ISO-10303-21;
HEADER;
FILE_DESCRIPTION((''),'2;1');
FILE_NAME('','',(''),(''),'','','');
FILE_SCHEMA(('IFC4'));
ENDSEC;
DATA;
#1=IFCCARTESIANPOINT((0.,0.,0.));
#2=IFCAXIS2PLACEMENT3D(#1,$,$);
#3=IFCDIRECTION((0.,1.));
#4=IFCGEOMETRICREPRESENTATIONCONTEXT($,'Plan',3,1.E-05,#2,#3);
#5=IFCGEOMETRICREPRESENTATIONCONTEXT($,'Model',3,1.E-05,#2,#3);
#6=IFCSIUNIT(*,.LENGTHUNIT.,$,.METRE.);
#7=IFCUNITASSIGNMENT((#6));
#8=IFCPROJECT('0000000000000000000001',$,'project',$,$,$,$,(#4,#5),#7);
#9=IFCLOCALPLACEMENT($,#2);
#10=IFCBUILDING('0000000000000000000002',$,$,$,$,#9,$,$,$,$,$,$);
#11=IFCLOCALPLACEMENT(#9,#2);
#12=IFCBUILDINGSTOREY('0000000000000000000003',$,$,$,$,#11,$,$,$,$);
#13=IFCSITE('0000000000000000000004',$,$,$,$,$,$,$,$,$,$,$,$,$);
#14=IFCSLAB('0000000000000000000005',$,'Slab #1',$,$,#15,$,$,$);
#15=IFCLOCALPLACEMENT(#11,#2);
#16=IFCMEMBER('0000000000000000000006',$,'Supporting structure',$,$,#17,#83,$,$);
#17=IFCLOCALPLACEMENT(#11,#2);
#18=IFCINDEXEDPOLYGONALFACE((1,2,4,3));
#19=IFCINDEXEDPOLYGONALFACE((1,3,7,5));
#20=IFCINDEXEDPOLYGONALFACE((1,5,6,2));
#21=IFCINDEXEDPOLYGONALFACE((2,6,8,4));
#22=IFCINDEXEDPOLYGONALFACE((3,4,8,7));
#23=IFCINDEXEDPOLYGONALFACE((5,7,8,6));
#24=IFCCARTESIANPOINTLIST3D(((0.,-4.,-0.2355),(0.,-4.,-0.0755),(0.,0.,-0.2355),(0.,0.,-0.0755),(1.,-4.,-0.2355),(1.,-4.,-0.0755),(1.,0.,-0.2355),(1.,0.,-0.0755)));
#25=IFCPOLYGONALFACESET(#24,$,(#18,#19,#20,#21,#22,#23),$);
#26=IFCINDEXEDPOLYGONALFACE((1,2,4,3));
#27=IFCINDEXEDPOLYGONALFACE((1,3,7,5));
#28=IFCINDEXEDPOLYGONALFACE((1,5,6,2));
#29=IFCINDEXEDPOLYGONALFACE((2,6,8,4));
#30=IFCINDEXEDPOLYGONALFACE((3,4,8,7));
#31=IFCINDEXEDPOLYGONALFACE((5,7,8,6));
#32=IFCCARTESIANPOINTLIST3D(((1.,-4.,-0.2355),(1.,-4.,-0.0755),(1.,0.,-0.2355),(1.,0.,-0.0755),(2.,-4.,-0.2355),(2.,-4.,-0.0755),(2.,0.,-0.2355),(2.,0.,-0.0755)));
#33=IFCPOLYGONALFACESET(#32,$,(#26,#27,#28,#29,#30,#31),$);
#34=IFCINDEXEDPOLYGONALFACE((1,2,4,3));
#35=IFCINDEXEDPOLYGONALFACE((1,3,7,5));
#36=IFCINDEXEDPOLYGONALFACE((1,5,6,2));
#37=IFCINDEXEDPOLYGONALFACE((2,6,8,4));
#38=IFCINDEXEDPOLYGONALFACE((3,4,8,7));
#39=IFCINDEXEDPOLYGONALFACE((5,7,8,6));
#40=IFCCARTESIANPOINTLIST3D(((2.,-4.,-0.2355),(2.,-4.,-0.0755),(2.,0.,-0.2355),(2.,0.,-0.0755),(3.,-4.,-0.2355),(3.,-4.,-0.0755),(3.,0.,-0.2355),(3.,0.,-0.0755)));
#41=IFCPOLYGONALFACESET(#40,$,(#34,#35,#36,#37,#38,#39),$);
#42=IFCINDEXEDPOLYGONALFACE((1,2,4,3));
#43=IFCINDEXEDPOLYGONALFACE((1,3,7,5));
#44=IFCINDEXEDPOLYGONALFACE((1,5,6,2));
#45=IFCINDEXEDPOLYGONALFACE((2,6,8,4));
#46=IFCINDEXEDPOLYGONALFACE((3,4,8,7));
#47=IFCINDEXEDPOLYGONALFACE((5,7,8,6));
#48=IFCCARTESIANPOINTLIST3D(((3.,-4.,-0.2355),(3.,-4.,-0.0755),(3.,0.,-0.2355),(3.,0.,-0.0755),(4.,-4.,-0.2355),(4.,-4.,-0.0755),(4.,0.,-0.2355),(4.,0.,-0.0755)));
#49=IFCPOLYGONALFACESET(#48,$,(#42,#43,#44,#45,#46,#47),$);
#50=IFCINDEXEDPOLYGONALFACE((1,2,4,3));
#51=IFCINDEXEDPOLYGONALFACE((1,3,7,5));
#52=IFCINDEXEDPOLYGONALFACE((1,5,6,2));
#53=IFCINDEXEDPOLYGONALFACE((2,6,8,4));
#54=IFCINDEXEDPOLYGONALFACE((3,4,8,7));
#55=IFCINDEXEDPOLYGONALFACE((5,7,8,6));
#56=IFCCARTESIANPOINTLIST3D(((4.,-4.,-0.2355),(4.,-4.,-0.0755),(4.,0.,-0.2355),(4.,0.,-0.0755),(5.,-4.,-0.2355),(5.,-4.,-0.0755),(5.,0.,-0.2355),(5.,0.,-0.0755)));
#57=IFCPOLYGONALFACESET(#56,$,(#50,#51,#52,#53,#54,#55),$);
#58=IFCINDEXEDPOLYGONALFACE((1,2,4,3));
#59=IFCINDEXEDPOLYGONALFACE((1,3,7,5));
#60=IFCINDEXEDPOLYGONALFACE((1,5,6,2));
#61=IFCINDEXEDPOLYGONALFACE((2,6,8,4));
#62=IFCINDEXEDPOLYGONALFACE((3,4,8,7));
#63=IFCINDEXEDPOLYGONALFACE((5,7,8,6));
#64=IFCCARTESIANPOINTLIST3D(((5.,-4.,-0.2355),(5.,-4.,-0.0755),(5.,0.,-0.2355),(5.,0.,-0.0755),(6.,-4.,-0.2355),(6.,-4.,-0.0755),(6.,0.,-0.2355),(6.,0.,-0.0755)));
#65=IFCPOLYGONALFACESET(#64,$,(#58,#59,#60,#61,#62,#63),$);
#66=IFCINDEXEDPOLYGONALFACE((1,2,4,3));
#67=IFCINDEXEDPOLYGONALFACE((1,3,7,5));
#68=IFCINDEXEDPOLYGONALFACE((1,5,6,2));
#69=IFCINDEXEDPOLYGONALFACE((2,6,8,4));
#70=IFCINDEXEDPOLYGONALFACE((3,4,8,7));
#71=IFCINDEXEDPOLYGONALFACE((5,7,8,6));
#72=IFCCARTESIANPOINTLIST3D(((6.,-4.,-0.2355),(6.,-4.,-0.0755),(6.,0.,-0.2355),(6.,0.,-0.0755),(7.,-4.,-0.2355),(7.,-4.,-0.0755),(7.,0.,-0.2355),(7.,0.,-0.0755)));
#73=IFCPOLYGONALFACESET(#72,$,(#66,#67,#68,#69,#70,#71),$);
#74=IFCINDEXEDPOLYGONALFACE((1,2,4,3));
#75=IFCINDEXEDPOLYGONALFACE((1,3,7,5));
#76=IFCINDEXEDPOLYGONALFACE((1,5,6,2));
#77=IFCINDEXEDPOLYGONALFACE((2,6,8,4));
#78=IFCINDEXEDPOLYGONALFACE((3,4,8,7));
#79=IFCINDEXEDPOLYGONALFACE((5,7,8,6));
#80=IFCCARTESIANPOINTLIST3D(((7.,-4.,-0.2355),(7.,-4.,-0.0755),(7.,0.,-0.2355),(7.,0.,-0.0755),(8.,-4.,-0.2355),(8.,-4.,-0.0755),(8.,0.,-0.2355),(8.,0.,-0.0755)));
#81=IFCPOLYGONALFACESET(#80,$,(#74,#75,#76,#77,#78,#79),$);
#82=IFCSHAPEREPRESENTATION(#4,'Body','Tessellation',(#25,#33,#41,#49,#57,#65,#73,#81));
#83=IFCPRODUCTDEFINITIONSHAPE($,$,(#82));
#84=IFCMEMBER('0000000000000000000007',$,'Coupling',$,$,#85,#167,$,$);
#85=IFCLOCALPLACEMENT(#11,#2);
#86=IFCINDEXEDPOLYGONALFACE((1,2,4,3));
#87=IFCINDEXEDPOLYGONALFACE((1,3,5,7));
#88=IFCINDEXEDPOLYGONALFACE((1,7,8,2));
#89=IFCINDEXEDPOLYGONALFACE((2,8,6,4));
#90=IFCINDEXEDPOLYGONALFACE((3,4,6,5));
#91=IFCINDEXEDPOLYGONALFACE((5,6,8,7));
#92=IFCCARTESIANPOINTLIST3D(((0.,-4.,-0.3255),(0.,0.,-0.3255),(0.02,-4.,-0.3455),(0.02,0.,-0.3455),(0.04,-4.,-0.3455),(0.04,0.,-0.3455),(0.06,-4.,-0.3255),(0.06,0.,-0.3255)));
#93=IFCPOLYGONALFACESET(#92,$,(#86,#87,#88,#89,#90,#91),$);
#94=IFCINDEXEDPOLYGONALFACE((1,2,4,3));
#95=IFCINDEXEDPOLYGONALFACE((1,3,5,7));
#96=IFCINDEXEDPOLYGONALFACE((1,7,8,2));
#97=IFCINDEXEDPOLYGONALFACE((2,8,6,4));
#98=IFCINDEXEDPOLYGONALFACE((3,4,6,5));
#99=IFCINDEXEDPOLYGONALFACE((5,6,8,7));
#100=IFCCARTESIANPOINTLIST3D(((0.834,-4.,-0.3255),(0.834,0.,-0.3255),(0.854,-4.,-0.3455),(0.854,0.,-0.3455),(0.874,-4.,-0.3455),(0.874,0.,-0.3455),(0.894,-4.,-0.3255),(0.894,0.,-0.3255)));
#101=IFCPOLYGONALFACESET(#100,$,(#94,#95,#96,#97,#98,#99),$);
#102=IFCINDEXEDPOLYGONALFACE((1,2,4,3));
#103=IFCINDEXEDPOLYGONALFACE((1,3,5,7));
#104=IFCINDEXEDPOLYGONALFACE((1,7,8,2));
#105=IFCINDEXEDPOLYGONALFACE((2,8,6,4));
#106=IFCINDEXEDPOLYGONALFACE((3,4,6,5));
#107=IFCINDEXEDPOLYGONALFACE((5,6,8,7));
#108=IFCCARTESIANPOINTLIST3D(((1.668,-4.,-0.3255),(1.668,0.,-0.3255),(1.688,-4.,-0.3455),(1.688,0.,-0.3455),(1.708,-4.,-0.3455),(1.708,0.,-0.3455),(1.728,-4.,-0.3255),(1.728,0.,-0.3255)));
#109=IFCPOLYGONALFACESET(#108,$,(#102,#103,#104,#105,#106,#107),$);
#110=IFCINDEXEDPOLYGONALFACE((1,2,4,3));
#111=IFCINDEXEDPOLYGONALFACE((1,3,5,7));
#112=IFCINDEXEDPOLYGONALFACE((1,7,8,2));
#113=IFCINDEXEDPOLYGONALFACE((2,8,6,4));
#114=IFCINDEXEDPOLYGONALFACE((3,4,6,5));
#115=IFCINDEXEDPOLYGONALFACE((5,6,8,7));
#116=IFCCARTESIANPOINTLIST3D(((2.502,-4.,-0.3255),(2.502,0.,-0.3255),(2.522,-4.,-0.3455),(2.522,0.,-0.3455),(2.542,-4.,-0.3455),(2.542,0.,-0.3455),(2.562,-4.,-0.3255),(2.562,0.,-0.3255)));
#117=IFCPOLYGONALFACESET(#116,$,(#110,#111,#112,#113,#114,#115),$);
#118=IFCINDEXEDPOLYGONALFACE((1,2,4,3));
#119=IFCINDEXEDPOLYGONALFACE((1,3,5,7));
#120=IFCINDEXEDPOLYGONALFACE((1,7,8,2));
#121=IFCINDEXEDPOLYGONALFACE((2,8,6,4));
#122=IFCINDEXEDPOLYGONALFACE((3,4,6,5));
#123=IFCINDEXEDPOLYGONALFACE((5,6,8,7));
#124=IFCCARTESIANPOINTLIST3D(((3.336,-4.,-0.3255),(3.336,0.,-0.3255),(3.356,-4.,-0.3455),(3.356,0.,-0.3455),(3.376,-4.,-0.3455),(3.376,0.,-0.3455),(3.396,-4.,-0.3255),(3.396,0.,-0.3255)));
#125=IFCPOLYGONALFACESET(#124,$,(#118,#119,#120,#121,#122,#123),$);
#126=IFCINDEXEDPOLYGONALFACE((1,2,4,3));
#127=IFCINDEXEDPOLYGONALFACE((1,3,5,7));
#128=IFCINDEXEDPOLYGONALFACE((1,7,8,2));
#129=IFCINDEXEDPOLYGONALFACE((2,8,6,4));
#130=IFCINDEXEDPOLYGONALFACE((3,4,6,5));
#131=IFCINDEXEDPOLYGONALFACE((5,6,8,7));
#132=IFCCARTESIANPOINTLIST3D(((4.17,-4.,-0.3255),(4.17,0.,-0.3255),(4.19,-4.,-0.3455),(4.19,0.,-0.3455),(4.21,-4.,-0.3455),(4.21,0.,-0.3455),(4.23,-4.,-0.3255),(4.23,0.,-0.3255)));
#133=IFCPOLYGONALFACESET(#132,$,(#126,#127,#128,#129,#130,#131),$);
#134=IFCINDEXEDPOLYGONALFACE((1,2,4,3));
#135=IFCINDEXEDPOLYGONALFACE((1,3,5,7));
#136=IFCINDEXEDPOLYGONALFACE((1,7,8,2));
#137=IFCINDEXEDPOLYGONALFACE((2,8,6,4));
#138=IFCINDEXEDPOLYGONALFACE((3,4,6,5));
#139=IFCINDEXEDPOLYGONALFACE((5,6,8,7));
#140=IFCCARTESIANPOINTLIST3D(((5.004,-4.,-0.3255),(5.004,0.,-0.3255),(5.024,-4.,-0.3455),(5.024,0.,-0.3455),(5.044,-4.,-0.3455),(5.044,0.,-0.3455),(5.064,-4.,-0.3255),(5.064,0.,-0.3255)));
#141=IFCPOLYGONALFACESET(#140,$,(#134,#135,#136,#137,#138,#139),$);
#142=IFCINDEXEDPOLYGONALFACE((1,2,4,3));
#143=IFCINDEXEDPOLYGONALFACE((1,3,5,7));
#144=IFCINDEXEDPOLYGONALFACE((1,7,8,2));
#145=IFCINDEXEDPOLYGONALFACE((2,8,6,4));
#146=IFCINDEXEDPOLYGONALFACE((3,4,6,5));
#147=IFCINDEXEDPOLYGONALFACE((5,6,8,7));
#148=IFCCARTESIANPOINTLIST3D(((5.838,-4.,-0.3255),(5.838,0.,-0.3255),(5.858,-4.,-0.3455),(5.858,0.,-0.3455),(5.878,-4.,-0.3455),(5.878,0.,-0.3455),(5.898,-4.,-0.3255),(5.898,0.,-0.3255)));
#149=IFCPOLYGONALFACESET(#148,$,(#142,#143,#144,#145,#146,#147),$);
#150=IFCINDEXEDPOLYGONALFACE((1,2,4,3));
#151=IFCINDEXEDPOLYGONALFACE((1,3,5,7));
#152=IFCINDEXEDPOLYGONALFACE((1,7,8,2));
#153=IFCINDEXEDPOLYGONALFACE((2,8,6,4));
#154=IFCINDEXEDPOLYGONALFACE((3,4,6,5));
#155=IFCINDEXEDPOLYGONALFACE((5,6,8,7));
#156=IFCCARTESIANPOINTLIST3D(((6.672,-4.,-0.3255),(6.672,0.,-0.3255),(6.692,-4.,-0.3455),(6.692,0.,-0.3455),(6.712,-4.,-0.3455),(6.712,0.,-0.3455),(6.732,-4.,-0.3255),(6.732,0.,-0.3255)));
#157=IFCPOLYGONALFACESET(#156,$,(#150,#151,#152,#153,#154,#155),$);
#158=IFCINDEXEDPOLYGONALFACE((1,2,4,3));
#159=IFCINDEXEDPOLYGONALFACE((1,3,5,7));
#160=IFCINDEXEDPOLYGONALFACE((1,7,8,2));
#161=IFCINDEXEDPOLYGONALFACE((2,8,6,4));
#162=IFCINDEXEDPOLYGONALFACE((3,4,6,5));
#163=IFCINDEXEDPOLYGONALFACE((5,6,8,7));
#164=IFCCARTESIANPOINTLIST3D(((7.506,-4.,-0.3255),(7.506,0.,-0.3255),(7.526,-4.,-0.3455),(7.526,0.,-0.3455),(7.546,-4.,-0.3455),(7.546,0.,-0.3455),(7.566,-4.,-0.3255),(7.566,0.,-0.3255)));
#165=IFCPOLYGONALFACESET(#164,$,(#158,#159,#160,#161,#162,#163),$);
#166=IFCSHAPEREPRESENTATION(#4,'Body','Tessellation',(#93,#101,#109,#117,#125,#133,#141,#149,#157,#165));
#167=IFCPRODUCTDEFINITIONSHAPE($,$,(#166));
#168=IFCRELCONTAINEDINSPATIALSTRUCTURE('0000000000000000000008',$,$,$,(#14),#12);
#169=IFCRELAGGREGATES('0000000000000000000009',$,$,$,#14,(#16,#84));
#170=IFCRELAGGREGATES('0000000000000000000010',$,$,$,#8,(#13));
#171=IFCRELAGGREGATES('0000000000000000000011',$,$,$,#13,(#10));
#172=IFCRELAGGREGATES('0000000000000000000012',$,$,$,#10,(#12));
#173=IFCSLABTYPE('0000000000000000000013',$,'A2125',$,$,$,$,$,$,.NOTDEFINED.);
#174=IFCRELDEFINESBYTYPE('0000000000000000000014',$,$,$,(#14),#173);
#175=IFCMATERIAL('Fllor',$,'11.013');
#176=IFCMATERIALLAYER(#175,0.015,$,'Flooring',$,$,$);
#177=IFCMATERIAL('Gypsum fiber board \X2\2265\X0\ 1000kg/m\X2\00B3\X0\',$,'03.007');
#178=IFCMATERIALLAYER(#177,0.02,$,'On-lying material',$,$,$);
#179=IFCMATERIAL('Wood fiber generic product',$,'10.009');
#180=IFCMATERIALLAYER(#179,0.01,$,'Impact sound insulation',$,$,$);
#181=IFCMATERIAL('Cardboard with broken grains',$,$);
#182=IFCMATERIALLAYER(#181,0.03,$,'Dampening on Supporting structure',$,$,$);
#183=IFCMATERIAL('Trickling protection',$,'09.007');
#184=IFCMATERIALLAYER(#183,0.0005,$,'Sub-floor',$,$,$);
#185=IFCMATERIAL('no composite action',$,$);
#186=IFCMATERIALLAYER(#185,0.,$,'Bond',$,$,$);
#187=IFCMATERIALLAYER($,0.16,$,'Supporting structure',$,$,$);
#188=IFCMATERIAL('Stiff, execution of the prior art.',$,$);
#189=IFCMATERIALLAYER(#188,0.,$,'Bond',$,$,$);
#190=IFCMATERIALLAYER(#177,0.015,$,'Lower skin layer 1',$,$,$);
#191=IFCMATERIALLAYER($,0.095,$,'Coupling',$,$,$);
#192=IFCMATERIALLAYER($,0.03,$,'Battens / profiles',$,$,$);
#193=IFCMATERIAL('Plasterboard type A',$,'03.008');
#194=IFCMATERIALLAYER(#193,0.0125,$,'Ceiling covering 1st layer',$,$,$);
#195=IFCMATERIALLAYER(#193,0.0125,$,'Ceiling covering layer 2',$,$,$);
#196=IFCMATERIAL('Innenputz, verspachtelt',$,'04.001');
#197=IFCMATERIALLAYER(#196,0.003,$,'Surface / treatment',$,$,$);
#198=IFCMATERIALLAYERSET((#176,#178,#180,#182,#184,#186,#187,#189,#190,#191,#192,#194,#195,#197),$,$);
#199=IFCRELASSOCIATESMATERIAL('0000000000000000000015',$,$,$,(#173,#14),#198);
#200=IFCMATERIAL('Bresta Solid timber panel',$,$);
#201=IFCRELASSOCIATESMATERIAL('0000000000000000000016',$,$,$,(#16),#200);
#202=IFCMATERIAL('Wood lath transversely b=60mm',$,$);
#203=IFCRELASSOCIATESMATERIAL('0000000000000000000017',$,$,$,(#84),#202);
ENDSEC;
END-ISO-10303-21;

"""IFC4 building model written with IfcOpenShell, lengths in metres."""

from ifc_helpers import new_model, si_unit, direction, frame, frame_2d, origin, place, context, project, spatial, polyline, rectangle, outline, extrude, material, layer, layer_set, type_object, element, aggregate, save


model = new_model("IFC4")

# Units and contexts
plan_context = context("Plan", 3, precision=1e-05, world=origin(), true_north=direction((0.0, 1.0)))
model_context = context("Model", 3, precision=1e-05, world=origin(), true_north=direction((0.0, 1.0)))
ifc_project = project(units=[si_unit("LENGTHUNIT", "METRE")], contexts=[plan_context, model_context])

# Site, building, storey
site = spatial("IfcSite", under=ifc_project)
building_placement = place(None, origin())
building = spatial("IfcBuilding", under=site, at=building_placement)
storey_placement = place(building_placement, origin())
storey = spatial("IfcBuildingStorey", under=building, at=storey_placement)

# Slab, members
ifc_material_1 = material(Name="Fllor", Category="11.013")
ifc_layer_1 = layer(ifc_material_1, 0.015, Name="Flooring")
ifc_material_2 = material(Name="Gypsum fiber board ≥ 1000kg/m³", Category="03.007")
ifc_layer_2 = layer(ifc_material_2, 0.02, Name="On-lying material")
ifc_material_3 = material(Name="Wood fiber generic product", Category="10.009")
ifc_layer_3 = layer(ifc_material_3, 0.01, Name="Impact sound insulation")
ifc_material_4 = material(Name="Cardboard with broken grains")
ifc_layer_4 = layer(ifc_material_4, 0.03, Name="Dampening on Supporting structure")
ifc_material_5 = material(Name="Trickling protection", Category="09.007")
ifc_layer_5 = layer(ifc_material_5, 0.0005, Name="Sub-floor")
ifc_material_6 = material(Name="no composite action")
ifc_layer_6 = layer(ifc_material_6, 0.0, Name="Bond")
ifc_layer_7 = layer(None, 0.16, Name="Supporting structure")
ifc_material_7 = material(Name="Stiff, execution of the prior art.")
ifc_layer_8 = layer(ifc_material_7, 0.0, Name="Bond")
ifc_layer_9 = layer(ifc_material_2, 0.015, Name="Lower skin layer 1")
ifc_layer_10 = layer(None, 0.095, Name="Coupling")
ifc_layer_11 = layer(None, 0.03, Name="Battens / profiles")
ifc_material_8 = material(Name="Plasterboard type A", Category="03.008")
ifc_layer_12 = layer(ifc_material_8, 0.0125, Name="Ceiling covering 1st layer")
ifc_layer_13 = layer(ifc_material_8, 0.0125, Name="Ceiling covering layer 2")
ifc_material_9 = material(Name="Innenputz, verspachtelt", Category="04.001")
ifc_layer_14 = layer(ifc_material_9, 0.003, Name="Surface / treatment")
ifc_layer_set = layer_set([ifc_layer_1, ifc_layer_2, ifc_layer_3, ifc_layer_4, ifc_layer_5, ifc_layer_6, ifc_layer_7, ifc_layer_8, ifc_layer_9, ifc_layer_10, ifc_layer_11, ifc_layer_12, ifc_layer_13, ifc_layer_14])
slab_type = type_object("IfcSlabType", Name="A2125", PredefinedType="NOTDEFINED", material=ifc_layer_set)
slab_placement = place(None, frame((0.0, 0.0, 0.0), z_axis=(0.0, 0.0, -1.0), x_axis=(1.0, 0.0, 0.0)))
slab = element("IfcSlab", 1, at=slab_placement, inside=storey, type_object=slab_type, material=ifc_layer_set, Name="Slab #1")
ifc_material_10 = material(Name="Bresta Solid timber panel")
member_1_placement = place(slab_placement, origin())
member_1 = element("IfcMember", 2, at=member_1_placement, material=ifc_material_10, Name="Supporting structure", context=plan_context, shape_type="SweptSolid", body=[
    extrude(rectangle(XDim=1.0, YDim=0.16, at=frame_2d((0.5, 0.08), x_axis=(1.0, 0.0))), frame((0.0, 4.0, 0.0755), z_axis=(0.0, -1.0, 0.0), x_axis=(1.0, 0.0, 0.0)), (0.0, 0.0, 1.0), 4.0),
    extrude(rectangle(XDim=1.0, YDim=0.16, at=frame_2d((0.5, 0.08), x_axis=(1.0, 0.0))), frame((1.0, 4.0, 0.0755), z_axis=(0.0, -1.0, 0.0), x_axis=(1.0, 0.0, 0.0)), (0.0, 0.0, 1.0), 4.0),
    extrude(rectangle(XDim=1.0, YDim=0.16, at=frame_2d((0.5, 0.08), x_axis=(1.0, 0.0))), frame((2.0, 4.0, 0.0755), z_axis=(0.0, -1.0, 0.0), x_axis=(1.0, 0.0, 0.0)), (0.0, 0.0, 1.0), 4.0),
    extrude(rectangle(XDim=1.0, YDim=0.16, at=frame_2d((0.5, 0.08), x_axis=(1.0, 0.0))), frame((3.0, 4.0, 0.0755), z_axis=(0.0, -1.0, 0.0), x_axis=(1.0, 0.0, 0.0)), (0.0, 0.0, 1.0), 4.0),
    extrude(rectangle(XDim=1.0, YDim=0.16, at=frame_2d((0.5, 0.08), x_axis=(1.0, 0.0))), frame((4.0, 4.0, 0.0755), z_axis=(0.0, -1.0, 0.0), x_axis=(1.0, 0.0, 0.0)), (0.0, 0.0, 1.0), 4.0),
    extrude(rectangle(XDim=1.0, YDim=0.16, at=frame_2d((0.5, 0.08), x_axis=(1.0, 0.0))), frame((5.0, 4.0, 0.0755), z_axis=(0.0, -1.0, 0.0), x_axis=(1.0, 0.0, 0.0)), (0.0, 0.0, 1.0), 4.0),
    extrude(rectangle(XDim=1.0, YDim=0.16, at=frame_2d((0.5, 0.08), x_axis=(1.0, 0.0))), frame((6.0, 4.0, 0.0755), z_axis=(0.0, -1.0, 0.0), x_axis=(1.0, 0.0, 0.0)), (0.0, 0.0, 1.0), 4.0),
    extrude(rectangle(XDim=1.0, YDim=0.16, at=frame_2d((0.5, 0.08), x_axis=(1.0, 0.0))), frame((7.0, 4.0, 0.0755), z_axis=(0.0, -1.0, 0.0), x_axis=(1.0, 0.0, 0.0)), (0.0, 0.0, 1.0), 4.0),
])
ifc_material_11 = material(Name="Wood lath transversely b=60mm")
member_2_placement = place(slab_placement, origin())
member_2 = element("IfcMember", 3, at=member_2_placement, material=ifc_material_11, Name="Coupling", context=plan_context, shape_type="SweptSolid", body=[
    extrude(outline(polyline([(0.0, 0.0), (0.06, 0.0), (0.04, 0.02), (0.02, 0.02), (0.0, 0.0)])), frame((0.0, 4.0, 0.3255), z_axis=(0.0, -1.0, 0.0), x_axis=(1.0, 0.0, 0.0)), (0.0, 0.0, 1.0), 4.0),
    extrude(outline(polyline([(0.0, 0.0), (0.06, 0.0), (0.04, 0.02), (0.02, 0.02), (0.0, 0.0)])), frame((0.834, 4.0, 0.3255), z_axis=(0.0, -1.0, 0.0), x_axis=(1.0, 0.0, 0.0)), (0.0, 0.0, 1.0), 4.0),
    extrude(outline(polyline([(0.0, 0.0), (0.06, 0.0), (0.04, 0.02), (0.02, 0.02), (0.0, 0.0)])), frame((1.668, 4.0, 0.3255), z_axis=(0.0, -1.0, 0.0), x_axis=(1.0, 0.0, 0.0)), (0.0, 0.0, 1.0), 4.0),
    extrude(outline(polyline([(0.0, 0.0), (0.06, 0.0), (0.04, 0.02), (0.02, 0.02), (0.0, 0.0)])), frame((2.502, 4.0, 0.3255), z_axis=(0.0, -1.0, 0.0), x_axis=(1.0, 0.0, 0.0)), (0.0, 0.0, 1.0), 4.0),
    extrude(outline(polyline([(0.0, 0.0), (0.06, 0.0), (0.04, 0.02), (0.02, 0.02), (0.0, 0.0)])), frame((3.336, 4.0, 0.3255), z_axis=(0.0, -1.0, 0.0), x_axis=(1.0, 0.0, 0.0)), (0.0, 0.0, 1.0), 4.0),
    extrude(outline(polyline([(0.0, 0.0), (0.06, 0.0), (0.04, 0.02), (0.02, 0.02), (0.0, 0.0)])), frame((4.17, 4.0, 0.3255), z_axis=(0.0, -1.0, 0.0), x_axis=(1.0, 0.0, 0.0)), (0.0, 0.0, 1.0), 4.0),
    extrude(outline(polyline([(0.0, 0.0), (0.06, 0.0), (0.04, 0.02), (0.02, 0.02), (0.0, 0.0)])), frame((5.004, 4.0, 0.3255), z_axis=(0.0, -1.0, 0.0), x_axis=(1.0, 0.0, 0.0)), (0.0, 0.0, 1.0), 4.0),
    extrude(outline(polyline([(0.0, 0.0), (0.06, 0.0), (0.04, 0.02), (0.02, 0.02), (0.0, 0.0)])), frame((5.838, 4.0, 0.3255), z_axis=(0.0, -1.0, 0.0), x_axis=(1.0, 0.0, 0.0)), (0.0, 0.0, 1.0), 4.0),
    extrude(outline(polyline([(0.0, 0.0), (0.06, 0.0), (0.04, 0.02), (0.02, 0.02), (0.0, 0.0)])), frame((6.672, 4.0, 0.3255), z_axis=(0.0, -1.0, 0.0), x_axis=(1.0, 0.0, 0.0)), (0.0, 0.0, 1.0), 4.0),
    extrude(outline(polyline([(0.0, 0.0), (0.06, 0.0), (0.04, 0.02), (0.02, 0.02), (0.0, 0.0)])), frame((7.506, 4.0, 0.3255), z_axis=(0.0, -1.0, 0.0), x_axis=(1.0, 0.0, 0.0)), (0.0, 0.0, 1.0), 4.0),
])
aggregate(slab, [member_1, member_2])

save(model, "model.ifc")
